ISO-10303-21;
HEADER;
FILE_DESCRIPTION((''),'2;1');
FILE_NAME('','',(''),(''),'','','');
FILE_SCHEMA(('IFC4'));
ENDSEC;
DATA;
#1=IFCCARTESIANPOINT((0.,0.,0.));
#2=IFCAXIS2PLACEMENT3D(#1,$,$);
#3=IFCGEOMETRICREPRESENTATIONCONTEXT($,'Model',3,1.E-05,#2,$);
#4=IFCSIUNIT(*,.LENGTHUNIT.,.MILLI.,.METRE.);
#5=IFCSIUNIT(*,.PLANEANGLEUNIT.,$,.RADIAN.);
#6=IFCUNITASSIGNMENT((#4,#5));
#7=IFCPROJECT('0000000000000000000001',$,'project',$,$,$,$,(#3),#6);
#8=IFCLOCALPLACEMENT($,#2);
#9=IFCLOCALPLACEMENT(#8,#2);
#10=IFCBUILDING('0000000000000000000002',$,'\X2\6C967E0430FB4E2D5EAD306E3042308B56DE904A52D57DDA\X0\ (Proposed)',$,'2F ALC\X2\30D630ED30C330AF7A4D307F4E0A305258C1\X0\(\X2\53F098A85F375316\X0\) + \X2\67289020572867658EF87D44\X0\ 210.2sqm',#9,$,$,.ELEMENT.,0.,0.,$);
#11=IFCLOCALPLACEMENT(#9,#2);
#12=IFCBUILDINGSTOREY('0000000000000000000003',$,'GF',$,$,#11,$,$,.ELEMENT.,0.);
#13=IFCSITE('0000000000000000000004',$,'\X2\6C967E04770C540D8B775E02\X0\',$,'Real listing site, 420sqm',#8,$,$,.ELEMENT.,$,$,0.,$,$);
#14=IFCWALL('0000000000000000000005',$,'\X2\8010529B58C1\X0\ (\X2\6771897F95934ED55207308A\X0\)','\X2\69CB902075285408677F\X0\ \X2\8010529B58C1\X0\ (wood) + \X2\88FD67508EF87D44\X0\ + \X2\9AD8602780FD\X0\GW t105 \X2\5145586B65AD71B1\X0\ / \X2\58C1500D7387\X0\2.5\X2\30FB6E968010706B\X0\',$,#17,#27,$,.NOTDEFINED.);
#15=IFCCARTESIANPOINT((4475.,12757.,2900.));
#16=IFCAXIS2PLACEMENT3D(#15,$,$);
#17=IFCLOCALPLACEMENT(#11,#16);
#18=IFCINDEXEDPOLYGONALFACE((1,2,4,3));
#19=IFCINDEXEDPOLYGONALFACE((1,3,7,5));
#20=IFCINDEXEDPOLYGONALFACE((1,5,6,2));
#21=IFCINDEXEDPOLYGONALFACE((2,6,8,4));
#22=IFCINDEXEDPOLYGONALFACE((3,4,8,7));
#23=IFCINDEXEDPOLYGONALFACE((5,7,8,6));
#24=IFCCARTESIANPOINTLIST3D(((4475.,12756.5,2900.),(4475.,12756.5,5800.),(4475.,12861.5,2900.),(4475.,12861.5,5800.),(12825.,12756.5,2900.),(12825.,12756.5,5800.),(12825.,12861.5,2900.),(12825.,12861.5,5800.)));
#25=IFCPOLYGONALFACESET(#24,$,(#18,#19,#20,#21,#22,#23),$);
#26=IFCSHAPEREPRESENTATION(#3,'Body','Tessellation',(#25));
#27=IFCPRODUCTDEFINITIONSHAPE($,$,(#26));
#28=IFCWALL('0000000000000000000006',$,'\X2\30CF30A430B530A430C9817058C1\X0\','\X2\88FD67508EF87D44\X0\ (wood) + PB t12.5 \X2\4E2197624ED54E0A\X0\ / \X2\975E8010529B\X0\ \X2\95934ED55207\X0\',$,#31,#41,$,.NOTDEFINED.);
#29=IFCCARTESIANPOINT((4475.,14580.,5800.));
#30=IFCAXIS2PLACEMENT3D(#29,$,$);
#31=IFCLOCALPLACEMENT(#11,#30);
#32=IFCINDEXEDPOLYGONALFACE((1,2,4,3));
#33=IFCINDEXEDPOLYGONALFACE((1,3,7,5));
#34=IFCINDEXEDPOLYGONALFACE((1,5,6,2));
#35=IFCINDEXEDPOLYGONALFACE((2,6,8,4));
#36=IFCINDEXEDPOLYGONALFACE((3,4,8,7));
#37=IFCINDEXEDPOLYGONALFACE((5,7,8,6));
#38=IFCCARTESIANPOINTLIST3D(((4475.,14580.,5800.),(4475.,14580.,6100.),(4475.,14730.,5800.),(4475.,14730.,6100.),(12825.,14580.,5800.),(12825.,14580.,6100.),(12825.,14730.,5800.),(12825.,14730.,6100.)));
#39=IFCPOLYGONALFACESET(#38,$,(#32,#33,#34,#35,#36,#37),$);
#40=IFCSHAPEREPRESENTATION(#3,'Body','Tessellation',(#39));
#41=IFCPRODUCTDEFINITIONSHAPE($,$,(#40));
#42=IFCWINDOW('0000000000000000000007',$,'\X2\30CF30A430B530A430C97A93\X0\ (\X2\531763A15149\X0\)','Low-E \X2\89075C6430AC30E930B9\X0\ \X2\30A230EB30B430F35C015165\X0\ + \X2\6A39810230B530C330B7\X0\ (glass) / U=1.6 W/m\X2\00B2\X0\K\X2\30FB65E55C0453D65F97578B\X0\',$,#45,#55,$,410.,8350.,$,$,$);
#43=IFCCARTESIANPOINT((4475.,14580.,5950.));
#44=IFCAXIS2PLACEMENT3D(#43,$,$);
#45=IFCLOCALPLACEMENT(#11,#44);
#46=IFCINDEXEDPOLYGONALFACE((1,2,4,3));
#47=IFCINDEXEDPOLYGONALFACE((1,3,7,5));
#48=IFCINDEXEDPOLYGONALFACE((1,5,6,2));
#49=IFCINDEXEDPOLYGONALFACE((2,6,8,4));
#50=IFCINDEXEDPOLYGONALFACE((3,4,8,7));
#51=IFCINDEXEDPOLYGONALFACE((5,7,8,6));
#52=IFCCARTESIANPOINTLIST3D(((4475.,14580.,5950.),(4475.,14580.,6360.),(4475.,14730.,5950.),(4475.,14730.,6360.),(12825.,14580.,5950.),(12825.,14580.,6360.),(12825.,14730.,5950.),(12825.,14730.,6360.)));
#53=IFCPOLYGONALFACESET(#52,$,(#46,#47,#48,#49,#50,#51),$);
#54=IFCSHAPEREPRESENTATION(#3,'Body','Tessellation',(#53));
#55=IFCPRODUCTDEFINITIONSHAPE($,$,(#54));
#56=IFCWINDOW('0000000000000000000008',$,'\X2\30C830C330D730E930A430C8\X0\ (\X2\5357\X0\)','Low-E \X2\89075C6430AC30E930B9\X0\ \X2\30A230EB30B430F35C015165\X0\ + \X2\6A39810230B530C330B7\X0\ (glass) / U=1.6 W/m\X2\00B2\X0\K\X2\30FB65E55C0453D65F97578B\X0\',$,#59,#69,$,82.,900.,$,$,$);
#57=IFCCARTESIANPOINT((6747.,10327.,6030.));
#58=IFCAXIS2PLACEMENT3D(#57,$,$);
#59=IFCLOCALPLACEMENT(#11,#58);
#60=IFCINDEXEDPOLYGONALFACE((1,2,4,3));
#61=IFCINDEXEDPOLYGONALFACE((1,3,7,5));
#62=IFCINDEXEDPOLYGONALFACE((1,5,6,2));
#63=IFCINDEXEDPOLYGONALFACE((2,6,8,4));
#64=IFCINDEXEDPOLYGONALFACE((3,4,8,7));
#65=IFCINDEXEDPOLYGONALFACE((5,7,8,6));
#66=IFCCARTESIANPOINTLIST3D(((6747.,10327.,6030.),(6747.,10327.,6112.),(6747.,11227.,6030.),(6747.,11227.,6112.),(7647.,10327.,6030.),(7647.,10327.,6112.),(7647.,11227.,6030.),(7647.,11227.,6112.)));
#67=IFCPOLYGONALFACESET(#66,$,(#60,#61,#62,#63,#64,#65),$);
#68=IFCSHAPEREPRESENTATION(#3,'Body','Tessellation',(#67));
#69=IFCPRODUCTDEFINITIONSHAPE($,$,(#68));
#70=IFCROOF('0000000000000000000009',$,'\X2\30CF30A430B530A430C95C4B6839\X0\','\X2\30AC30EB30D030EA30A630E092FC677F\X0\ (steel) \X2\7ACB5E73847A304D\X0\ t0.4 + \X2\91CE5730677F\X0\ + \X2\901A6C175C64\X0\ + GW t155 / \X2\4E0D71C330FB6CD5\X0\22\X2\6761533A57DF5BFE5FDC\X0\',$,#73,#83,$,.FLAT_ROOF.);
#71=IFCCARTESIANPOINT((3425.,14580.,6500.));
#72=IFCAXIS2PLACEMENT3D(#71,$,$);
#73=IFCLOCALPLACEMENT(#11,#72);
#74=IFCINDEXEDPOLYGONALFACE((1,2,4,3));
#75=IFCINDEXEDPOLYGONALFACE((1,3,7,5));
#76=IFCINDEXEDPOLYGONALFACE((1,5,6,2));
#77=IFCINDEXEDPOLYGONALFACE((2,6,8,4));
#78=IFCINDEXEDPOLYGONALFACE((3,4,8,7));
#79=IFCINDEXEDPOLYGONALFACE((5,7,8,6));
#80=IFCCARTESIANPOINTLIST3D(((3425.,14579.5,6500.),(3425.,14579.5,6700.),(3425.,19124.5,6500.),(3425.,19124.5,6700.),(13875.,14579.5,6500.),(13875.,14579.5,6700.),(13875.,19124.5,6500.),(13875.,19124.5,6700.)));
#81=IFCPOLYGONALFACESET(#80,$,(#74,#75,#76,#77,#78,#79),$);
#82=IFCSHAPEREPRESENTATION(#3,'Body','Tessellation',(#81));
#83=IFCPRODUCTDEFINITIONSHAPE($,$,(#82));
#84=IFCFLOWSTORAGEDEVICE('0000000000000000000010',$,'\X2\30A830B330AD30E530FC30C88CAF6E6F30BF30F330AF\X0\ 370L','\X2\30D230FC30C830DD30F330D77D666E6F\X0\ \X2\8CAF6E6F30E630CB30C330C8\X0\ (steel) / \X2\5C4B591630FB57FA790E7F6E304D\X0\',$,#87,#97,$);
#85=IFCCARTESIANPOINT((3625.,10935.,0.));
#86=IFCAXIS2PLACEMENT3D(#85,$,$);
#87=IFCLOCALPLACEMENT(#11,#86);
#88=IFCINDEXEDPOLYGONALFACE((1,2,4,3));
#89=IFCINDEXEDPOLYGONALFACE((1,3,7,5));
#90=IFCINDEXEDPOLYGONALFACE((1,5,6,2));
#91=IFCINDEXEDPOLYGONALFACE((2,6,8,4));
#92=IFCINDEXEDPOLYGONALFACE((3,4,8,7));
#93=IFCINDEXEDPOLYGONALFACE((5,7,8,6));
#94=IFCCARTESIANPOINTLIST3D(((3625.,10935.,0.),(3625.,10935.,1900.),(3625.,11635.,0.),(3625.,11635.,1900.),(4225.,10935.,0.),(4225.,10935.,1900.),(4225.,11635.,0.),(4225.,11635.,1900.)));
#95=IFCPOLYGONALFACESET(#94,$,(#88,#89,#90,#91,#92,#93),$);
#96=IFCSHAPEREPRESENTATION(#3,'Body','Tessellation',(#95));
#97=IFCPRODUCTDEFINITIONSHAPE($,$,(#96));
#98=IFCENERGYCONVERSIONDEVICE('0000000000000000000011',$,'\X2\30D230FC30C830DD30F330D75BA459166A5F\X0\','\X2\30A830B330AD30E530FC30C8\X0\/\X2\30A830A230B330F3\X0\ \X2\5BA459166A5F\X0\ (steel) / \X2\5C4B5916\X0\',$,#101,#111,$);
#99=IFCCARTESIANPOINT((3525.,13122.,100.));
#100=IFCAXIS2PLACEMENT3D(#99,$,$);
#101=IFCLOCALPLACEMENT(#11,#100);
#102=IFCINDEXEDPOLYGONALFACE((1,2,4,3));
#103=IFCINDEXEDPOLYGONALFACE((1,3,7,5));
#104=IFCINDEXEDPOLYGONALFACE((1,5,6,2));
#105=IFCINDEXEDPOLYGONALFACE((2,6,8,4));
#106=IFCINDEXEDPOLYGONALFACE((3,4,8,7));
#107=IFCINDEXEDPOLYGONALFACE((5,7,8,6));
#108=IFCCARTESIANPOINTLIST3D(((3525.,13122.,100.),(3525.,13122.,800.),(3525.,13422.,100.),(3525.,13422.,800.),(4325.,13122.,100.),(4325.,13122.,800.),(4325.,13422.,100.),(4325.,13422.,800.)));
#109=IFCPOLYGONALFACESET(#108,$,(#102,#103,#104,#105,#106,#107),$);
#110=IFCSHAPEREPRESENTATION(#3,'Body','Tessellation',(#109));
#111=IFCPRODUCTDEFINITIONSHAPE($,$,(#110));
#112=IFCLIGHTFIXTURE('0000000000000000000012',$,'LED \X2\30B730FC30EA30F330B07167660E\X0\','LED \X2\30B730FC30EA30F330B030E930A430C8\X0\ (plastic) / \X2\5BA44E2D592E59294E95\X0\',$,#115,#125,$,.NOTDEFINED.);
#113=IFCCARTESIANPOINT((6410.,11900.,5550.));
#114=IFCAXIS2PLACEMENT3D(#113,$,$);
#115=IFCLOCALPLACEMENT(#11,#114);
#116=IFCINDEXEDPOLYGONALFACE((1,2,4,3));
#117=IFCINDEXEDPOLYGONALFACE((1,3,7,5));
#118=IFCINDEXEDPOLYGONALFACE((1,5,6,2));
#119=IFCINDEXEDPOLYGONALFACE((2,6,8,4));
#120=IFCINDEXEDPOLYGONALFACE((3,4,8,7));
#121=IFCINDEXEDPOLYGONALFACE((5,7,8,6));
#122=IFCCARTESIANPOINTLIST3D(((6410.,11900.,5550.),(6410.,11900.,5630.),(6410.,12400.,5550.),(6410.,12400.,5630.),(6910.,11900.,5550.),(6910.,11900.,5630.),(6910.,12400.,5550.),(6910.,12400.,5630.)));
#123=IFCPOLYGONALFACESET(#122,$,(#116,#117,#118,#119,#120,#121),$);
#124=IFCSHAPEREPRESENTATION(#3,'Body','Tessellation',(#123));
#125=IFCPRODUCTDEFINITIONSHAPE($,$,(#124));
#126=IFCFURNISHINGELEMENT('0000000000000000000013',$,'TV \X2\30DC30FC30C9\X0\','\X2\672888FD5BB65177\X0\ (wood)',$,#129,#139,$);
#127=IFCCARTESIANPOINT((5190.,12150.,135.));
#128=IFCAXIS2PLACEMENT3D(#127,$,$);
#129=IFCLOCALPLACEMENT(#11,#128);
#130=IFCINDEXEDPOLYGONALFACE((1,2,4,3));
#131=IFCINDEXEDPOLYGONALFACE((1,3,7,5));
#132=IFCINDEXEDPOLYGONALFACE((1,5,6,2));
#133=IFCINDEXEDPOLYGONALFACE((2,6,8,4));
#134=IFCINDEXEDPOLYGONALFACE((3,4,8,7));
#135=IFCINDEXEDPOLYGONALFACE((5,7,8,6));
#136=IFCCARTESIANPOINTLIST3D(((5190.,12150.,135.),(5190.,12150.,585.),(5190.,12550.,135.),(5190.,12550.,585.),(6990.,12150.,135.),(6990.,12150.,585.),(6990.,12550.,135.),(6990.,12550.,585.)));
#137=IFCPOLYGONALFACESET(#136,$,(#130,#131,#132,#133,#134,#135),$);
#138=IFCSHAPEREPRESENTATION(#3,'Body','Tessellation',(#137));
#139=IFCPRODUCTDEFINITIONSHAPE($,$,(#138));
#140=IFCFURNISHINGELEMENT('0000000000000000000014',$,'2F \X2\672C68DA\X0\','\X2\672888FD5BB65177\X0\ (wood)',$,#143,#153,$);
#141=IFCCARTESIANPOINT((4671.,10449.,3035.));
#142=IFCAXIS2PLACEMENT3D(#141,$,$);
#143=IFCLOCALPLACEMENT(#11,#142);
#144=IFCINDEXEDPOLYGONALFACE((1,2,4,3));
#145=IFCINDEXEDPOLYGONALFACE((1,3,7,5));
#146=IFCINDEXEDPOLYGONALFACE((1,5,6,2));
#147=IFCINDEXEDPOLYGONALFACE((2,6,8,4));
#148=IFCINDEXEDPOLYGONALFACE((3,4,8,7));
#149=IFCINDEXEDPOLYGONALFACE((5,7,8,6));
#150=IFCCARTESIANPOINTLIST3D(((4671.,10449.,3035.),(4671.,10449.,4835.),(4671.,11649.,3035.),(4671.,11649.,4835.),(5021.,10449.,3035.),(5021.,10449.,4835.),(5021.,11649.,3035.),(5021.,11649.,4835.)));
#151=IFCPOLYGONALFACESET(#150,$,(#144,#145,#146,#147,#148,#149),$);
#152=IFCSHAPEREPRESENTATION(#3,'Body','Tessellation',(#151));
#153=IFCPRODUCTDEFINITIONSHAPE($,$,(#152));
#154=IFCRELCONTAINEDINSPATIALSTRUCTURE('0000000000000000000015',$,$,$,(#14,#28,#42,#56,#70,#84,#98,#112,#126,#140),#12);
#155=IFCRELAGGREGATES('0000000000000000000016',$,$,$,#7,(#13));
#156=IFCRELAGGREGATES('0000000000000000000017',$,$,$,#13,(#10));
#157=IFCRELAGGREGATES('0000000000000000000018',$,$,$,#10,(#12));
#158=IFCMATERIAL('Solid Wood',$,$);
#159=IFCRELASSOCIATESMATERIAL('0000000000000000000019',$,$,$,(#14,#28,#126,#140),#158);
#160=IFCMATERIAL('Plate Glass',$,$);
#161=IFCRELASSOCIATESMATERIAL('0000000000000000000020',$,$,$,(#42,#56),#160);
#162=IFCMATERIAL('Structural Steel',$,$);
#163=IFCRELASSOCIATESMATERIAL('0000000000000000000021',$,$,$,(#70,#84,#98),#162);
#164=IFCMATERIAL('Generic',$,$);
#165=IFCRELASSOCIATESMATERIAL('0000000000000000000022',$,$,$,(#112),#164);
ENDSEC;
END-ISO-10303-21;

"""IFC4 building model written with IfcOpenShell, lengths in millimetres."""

from ifc_helpers import new_model, si_unit, frame, frame_2d, origin, place, context, project, spatial, rectangle, extrude, material, element, fill, save


model = new_model("IFC4")

# Units and contexts
model_context = context("Model", 3, precision=1e-05, world=origin())
ifc_project = project(units=[si_unit("LENGTHUNIT", "METRE", prefix="MILLI"), si_unit("PLANEANGLEUNIT", "RADIAN")], contexts=[model_context])

# Site, building, storey
site_placement = place(None, origin())
site = spatial("IfcSite", under=ifc_project, at=site_placement, Name="沖縄県名護市", ObjectType="Real listing site, 420sqm", CompositionType="ELEMENT", RefElevation=0.0)
building_placement = place(site_placement, origin())
building = spatial("IfcBuilding", under=site, at=building_placement, Name="沖縄・中庭のある回遊動線 (Proposed)", ObjectType="2F ALCブロック積み上げ壁(台風強化) + 木造在来軸組 210.2sqm", CompositionType="ELEMENT", ElevationOfRefHeight=0.0, ElevationOfTerrain=0.0)
storey_placement = place(building_placement, origin())
storey = spatial("IfcBuildingStorey", under=building, at=storey_placement, Name="GF", CompositionType="ELEMENT", Elevation=0.0)

# Shared definitions
ifc_material_1 = material(Name="Solid Wood")

# Wall
wall_1_placement = place(storey_placement, frame((4475.0, 12757.0, 2900.0)))
element("IfcWall", 1, at=wall_1_placement, inside=storey, material=ifc_material_1, Name="耐力壁 (東西間仕切り)", Description="構造用合板 耐力壁 (wood) + 製材軸組 + 高性能GW t105 充填断熱 / 壁倍率2.5・準耐火", PredefinedType="NOTDEFINED", context=model_context, shape_type="SweptSolid", body=[
    extrude(rectangle(XDim=8350.0, YDim=105.0, at=frame_2d((4175.0, 52.0))), frame((4475.0, 12757.0, 2900.0)), (0.0, 0.0, 1.0), 2900.0),
])

# Wall, opening, window
wall_2_placement = place(storey_placement, frame((4475.0, 14580.0, 5800.0)))
wall_2 = element("IfcWall", 2, at=wall_2_placement, inside=storey, material=ifc_material_1, Name="ハイサイド腰壁", Description="製材軸組 (wood) + PB t12.5 両面仕上 / 非耐力 間仕切", PredefinedType="NOTDEFINED", context=model_context, shape_type="SweptSolid", body=[
    extrude(rectangle(XDim=8350.0, YDim=150.0, at=frame_2d((4175.0, 75.0))), frame((4475.0, 14580.0, 5800.0)), (0.0, 0.0, 1.0), 700.0),
])
opening_1_placement = place(storey_placement, frame((4475.0, 14580.0, 5950.0)))
opening_1 = element("IfcOpeningElement", 3, at=opening_1_placement, cuts=wall_2, PredefinedType="NOTDEFINED", context=model_context, shape_type="SweptSolid", body=[
    extrude(rectangle(XDim=8350.0, YDim=150.0, at=frame_2d((4175.0, 75.0))), frame((4475.0, 14580.0, 5950.0)), (0.0, 0.0, 1.0), 410.0),
])
ifc_material_2 = material(Name="Plate Glass")
window_1_placement = place(storey_placement, frame((4475.0, 14580.0, 5950.0)))
window_1 = element("IfcWindow", 4, at=window_1_placement, inside=storey, material=ifc_material_2, Name="ハイサイド窓 (北採光)", Description="Low-E 複層ガラス アルゴン封入 + 樹脂サッシ (glass) / U=1.6 W/m²K・日射取得型", OverallHeight=410.0, OverallWidth=8350.0, context=model_context, shape_type="SweptSolid", body=[
    extrude(rectangle(XDim=8350.0, YDim=150.0, at=frame_2d((4175.0, 75.0))), frame((4475.0, 14580.0, 5950.0)), (0.0, 0.0, 1.0), 410.0),
])
fill(opening_1, window_1)

# Window
window_2_placement = place(storey_placement, frame((6747.0, 10327.0, 6030.0)))
element("IfcWindow", 5, at=window_2_placement, inside=storey, material=ifc_material_2, Name="トップライト (南)", Description="Low-E 複層ガラス アルゴン封入 + 樹脂サッシ (glass) / U=1.6 W/m²K・日射取得型", OverallHeight=82.0, OverallWidth=900.0, context=model_context, shape_type="SweptSolid", body=[
    extrude(rectangle(XDim=900.0, YDim=900.0, at=frame_2d((450.0, 450.0))), frame((6747.0, 10327.0, 6030.0)), (0.0, 0.0, 1.0), 82.0),
])

# Roof
ifc_material_3 = material(Name="Structural Steel")
roof_placement = place(storey_placement, frame((3425.0, 14580.0, 6500.0)))
element("IfcRoof", 6, at=roof_placement, inside=storey, material=ifc_material_3, Name="ハイサイド屋根", Description="ガルバリウム鋼板 (steel) 立平葺き t0.4 + 野地板 + 通気層 + GW t155 / 不燃・法22条区域対応", PredefinedType="FLAT_ROOF", context=model_context, shape_type="SweptSolid", body=[
    extrude(rectangle(XDim=10450.0, YDim=4545.0, at=frame_2d((5225.0, 2272.0))), frame((3425.0, 14580.0, 6500.0)), (0.0, 0.0, 1.0), 200.0),
])

# Flow storage device
flow_storage_device_placement = place(storey_placement, frame((3625.0, 10935.0, 0.0)))
element("IfcFlowStorageDevice", 7, at=flow_storage_device_placement, inside=storey, material=ifc_material_3, Name="エコキュート貯湯タンク 370L", Description="ヒートポンプ給湯 貯湯ユニット (steel) / 屋外・基礎置き", context=model_context, shape_type="SweptSolid", body=[
    extrude(rectangle(XDim=600.0, YDim=700.0, at=frame_2d((300.0, 350.0))), frame((3625.0, 10935.0, 0.0)), (0.0, 0.0, 1.0), 1900.0),
])

# Energy conversion device
energy_conversion_device_placement = place(storey_placement, frame((3525.0, 13122.0, 100.0)))
element("IfcEnergyConversionDevice", 8, at=energy_conversion_device_placement, inside=storey, material=ifc_material_3, Name="ヒートポンプ室外機", Description="エコキュート/エアコン 室外機 (steel) / 屋外", context=model_context, shape_type="SweptSolid", body=[
    extrude(rectangle(XDim=800.0, YDim=300.0, at=frame_2d((400.0, 150.0))), frame((3525.0, 13122.0, 100.0)), (0.0, 0.0, 1.0), 700.0),
])

# Light fixture
ifc_material_4 = material(Name="Generic")
light_fixture_placement = place(storey_placement, frame((6410.0, 11900.0, 5550.0)))
element("IfcLightFixture", 9, at=light_fixture_placement, inside=storey, material=ifc_material_4, Name="LED シーリング照明", Description="LED シーリングライト (plastic) / 室中央天井", PredefinedType="NOTDEFINED", context=model_context, shape_type="SweptSolid", body=[
    extrude(rectangle(XDim=500.0, YDim=500.0, at=frame_2d((250.0, 250.0))), frame((6410.0, 11900.0, 5550.0)), (0.0, 0.0, 1.0), 80.0),
])

# Furnishing elements
furnishing_1_placement = place(storey_placement, frame((5190.0, 12150.0, 135.0)))
element("IfcFurnishingElement", 10, at=furnishing_1_placement, inside=storey, material=ifc_material_1, Name="TV ボード", Description="木製家具 (wood)", context=model_context, shape_type="SweptSolid", body=[
    extrude(rectangle(XDim=1800.0, YDim=400.0, at=frame_2d((900.0, 200.0))), frame((5190.0, 12150.0, 135.0)), (0.0, 0.0, 1.0), 450.0),
])
furnishing_2_placement = place(storey_placement, frame((4671.0, 10449.0, 3035.0)))
element("IfcFurnishingElement", 11, at=furnishing_2_placement, inside=storey, material=ifc_material_1, Name="2F 本棚", Description="木製家具 (wood)", context=model_context, shape_type="SweptSolid", body=[
    extrude(rectangle(XDim=350.0, YDim=1200.0, at=frame_2d((175.0, 600.0))), frame((4671.0, 10449.0, 3035.0)), (0.0, 0.0, 1.0), 1800.0),
])

save(model, "model.ifc")
